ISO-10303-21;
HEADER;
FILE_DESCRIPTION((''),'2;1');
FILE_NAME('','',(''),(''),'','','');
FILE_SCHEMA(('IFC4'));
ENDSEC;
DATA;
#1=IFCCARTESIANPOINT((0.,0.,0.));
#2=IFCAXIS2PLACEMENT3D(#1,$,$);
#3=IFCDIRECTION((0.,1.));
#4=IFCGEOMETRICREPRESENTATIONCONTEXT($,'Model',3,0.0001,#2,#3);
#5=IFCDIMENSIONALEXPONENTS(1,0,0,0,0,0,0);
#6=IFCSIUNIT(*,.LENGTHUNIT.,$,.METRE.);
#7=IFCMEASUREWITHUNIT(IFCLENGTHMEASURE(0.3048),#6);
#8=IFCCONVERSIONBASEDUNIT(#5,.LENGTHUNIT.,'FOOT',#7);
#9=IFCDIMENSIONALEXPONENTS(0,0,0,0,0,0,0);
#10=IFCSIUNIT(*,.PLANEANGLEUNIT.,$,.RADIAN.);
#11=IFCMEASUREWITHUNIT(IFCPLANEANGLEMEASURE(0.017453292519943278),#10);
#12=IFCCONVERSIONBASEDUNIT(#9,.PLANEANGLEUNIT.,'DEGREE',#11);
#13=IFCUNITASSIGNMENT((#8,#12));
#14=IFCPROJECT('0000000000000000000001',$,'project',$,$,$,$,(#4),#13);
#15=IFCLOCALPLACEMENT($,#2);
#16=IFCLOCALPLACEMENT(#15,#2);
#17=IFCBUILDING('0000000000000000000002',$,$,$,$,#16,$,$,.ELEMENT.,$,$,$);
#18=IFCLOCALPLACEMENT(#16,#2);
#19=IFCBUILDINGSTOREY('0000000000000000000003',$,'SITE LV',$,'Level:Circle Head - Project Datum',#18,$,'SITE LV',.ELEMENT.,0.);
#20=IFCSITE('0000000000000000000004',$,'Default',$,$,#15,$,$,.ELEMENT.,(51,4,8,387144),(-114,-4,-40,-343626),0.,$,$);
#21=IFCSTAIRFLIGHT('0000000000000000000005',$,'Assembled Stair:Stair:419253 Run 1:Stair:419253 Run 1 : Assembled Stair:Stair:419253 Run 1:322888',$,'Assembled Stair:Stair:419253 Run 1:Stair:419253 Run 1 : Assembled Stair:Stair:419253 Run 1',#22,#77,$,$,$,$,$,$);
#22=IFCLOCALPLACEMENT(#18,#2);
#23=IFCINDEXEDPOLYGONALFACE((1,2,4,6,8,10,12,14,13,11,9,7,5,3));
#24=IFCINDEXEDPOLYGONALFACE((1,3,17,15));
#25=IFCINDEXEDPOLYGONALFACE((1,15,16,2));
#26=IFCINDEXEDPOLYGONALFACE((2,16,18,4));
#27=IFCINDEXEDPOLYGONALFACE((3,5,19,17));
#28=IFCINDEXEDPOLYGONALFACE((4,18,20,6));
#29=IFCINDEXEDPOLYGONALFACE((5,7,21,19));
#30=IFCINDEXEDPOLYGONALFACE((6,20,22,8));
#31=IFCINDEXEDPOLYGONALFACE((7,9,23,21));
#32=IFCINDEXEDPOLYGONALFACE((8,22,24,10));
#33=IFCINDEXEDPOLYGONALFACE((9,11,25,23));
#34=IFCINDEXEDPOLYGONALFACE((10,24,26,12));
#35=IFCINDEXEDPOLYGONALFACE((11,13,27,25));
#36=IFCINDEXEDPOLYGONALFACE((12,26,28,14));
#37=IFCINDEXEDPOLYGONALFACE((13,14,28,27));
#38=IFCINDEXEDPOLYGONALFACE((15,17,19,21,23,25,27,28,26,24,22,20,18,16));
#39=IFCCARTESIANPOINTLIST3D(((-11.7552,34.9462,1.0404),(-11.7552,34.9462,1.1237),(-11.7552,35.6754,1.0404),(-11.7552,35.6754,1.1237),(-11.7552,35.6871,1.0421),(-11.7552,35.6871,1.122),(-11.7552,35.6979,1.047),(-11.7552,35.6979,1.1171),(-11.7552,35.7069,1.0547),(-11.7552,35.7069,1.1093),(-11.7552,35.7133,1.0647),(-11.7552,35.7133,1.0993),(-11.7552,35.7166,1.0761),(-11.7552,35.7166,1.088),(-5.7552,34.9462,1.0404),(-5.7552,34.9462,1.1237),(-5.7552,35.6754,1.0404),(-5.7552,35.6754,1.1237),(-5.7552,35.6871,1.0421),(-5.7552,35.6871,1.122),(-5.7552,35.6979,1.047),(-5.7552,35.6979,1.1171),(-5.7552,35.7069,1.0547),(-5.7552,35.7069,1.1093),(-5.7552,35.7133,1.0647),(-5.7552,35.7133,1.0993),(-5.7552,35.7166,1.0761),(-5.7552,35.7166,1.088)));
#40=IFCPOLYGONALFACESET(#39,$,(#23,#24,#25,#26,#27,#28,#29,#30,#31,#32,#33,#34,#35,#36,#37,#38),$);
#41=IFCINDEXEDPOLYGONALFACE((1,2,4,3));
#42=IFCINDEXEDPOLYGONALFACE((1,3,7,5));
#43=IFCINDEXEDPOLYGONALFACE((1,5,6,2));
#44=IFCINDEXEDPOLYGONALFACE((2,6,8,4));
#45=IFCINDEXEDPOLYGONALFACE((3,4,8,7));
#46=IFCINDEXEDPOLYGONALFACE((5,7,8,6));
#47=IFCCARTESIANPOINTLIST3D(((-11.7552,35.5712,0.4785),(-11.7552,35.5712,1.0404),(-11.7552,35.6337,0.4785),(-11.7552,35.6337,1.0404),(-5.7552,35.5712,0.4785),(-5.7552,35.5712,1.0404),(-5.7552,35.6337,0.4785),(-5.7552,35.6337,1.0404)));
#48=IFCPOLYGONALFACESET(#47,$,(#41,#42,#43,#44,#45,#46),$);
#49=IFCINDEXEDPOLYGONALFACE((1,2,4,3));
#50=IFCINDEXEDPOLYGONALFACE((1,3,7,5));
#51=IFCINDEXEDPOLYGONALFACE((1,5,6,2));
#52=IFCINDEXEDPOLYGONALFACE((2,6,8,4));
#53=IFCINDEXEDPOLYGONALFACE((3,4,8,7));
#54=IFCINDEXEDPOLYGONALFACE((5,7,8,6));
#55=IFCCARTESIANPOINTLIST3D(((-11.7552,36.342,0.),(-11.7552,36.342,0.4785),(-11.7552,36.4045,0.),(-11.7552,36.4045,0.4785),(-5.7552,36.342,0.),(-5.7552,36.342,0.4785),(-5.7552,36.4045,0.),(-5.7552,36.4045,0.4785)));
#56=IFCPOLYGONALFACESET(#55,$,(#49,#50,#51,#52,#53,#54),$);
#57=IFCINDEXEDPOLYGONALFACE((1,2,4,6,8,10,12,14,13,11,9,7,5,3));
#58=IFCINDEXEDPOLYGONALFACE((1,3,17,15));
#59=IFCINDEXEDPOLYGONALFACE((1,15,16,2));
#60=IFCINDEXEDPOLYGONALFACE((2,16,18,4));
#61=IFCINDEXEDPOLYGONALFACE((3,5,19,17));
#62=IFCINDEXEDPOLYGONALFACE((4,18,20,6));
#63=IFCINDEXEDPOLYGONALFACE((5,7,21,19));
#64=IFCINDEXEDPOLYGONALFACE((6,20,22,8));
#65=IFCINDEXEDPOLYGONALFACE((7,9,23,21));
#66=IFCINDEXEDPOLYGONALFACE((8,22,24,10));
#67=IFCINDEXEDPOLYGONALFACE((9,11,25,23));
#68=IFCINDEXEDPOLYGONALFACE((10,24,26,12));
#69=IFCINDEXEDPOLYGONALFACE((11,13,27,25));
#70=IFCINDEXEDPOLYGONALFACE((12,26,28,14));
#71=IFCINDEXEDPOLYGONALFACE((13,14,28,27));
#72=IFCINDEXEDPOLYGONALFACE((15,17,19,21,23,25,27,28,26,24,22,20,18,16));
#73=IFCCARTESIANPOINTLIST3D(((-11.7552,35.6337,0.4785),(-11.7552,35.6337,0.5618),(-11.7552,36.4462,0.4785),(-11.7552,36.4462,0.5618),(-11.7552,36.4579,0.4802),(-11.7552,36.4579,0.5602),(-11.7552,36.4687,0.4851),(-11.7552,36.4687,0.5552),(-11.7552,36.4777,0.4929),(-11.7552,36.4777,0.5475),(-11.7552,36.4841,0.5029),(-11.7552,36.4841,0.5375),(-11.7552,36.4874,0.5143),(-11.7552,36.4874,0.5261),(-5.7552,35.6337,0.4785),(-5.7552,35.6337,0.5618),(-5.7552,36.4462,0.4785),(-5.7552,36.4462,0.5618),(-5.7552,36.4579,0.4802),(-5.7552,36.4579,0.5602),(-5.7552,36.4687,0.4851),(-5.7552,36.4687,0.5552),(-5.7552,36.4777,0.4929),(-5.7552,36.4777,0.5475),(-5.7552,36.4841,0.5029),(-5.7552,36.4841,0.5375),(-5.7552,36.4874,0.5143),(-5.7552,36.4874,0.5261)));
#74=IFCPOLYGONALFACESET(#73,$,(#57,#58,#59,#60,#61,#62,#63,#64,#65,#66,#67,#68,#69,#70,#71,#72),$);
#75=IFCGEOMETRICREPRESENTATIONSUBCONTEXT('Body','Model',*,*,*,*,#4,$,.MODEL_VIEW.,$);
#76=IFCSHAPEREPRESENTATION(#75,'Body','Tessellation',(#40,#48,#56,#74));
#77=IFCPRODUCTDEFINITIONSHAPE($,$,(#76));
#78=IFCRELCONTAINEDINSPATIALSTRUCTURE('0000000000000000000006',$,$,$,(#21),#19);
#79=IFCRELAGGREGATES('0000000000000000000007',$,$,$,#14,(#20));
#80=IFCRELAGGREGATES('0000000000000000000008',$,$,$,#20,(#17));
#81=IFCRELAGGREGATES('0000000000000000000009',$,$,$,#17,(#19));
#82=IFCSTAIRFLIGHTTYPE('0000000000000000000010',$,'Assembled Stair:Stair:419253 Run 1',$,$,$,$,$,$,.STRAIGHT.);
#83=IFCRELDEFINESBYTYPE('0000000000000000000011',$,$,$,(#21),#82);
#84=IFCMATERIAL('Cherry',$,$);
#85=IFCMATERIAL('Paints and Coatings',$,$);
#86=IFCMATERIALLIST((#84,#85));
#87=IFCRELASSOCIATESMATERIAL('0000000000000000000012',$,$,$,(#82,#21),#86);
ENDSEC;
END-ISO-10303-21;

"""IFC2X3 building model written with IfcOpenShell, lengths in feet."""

from ifc_helpers import new_model, entity, si_unit, converted_unit, direction, frame, frame_2d, origin, place, context, subcontext, project, spatial, polyline, circle_curve, parameter, trimmed, segment, composite_curve, rectangle, outline, extrude, source, transform, mapped, material, material_list, type_object, type_shapes, element, save


model = new_model("IFC2X3")

# Units and contexts
model_context = context("Model", 3, precision=0.0001, world=origin(), true_north=direction((0.0, 1.0)))
body_context = subcontext(model_context, "Body", "Model", "MODEL_VIEW")
ifc_project = project(units=[converted_unit("LENGTHUNIT", "FOOT", entity("IfcLengthMeasure", 0.3048), si_unit("LENGTHUNIT", "METRE"), dimensions=[1, 0, 0, 0, 0, 0, 0]), converted_unit("PLANEANGLEUNIT", "DEGREE", entity("IfcPlaneAngleMeasure", 0.017453292519943278), si_unit("PLANEANGLEUNIT", "RADIAN"), dimensions=[0, 0, 0, 0, 0, 0, 0])], contexts=[model_context])

# Site, building, storey
site_placement = place(None, origin())
site = spatial("IfcSite", under=ifc_project, at=site_placement, Name="Default", CompositionType="ELEMENT", RefLatitude=(51, 4, 8, 387144), RefLongitude=(-114, -4, -40, -343626), RefElevation=0.0)
building_placement = place(site_placement, origin())
building = spatial("IfcBuilding", under=site, at=building_placement, CompositionType="ELEMENT")
storey_placement = place(building_placement, origin())
storey = spatial("IfcBuildingStorey", under=building, at=storey_placement, Name="SITE LV", ObjectType="Level:Circle Head - Project Datum", LongName="SITE LV", CompositionType="ELEMENT", Elevation=0.0)

# Shared definitions
ifc_material_1 = material(Name="Paints and Coatings")

# Stair flight
ifc_material_2 = material(Name="Cherry")
ifc_material_list = material_list([ifc_material_2, ifc_material_1])
stair_flight_type = type_object("IfcStairFlightType", Name="Assembled Stair:Stair:419253 Run 1", PredefinedType="STRAIGHT", material=ifc_material_list)
shared_shape_1 = source(origin(), body_context, "Body", "SweptSolid", [
    extrude(outline(composite_curve([segment(trimmed(circle_curve(frame_2d((-0.3646, 0.0), x_axis=(1.0, 0.0)), 0.0417), [parameter(90.0)], [parameter(270.0)], True, "PARAMETER"), True, "CONTINUOUS"), segment(polyline([(-0.3646, -0.0417), (0.3646, -0.0417)]), True, "CONTINUOUS"), segment(polyline([(0.3646, -0.0417), (0.3646, 0.0417)]), True, "CONTINUOUS"), segment(polyline([(0.3646, 0.0417), (-0.3646, 0.0417)]), True, "CONTINUOUS")], self_intersect=False)), frame((-11.7552, 35.3108, 1.082), z_axis=(1.0, 0.0, 0.0), x_axis=(0.0, -1.0, 0.0)), (0.0, 0.0, 1.0), 6.0),
    extrude(rectangle(XDim=0.0625, YDim=6.0, at=frame_2d((0.0, 0.0), x_axis=(1.0, 0.0))), frame((-8.7552, 35.6024, 0.4785), z_axis=(0.0, 0.0, 1.0), x_axis=(0.0, 1.0, 0.0)), (0.0, 0.0, 1.0), 0.5618),
    extrude(rectangle(XDim=0.0625, YDim=6.0, at=frame_2d((0.0, 0.0), x_axis=(1.0, 0.0))), frame((-8.7552, 36.3733, 0.0), z_axis=(0.0, 0.0, 1.0), x_axis=(0.0, 1.0, 0.0)), (0.0, 0.0, 1.0), 0.4785),
    extrude(outline(composite_curve([segment(trimmed(circle_curve(frame_2d((-0.4062, 0.0), x_axis=(1.0, 0.0)), 0.0417), [parameter(90.0)], [parameter(270.0)], True, "PARAMETER"), True, "CONTINUOUS"), segment(polyline([(-0.4062, -0.0417), (0.4062, -0.0417)]), True, "CONTINUOUS"), segment(polyline([(0.4062, -0.0417), (0.4062, 0.0417)]), True, "CONTINUOUS"), segment(polyline([(0.4062, 0.0417), (-0.4062, 0.0417)]), True, "CONTINUOUS")], self_intersect=False)), frame((-11.7552, 36.0399, 0.5202), z_axis=(1.0, 0.0, 0.0), x_axis=(0.0, -1.0, 0.0)), (0.0, 0.0, 1.0), 6.0),
])
type_shapes(stair_flight_type, [shared_shape_1])
stair_flight_placement = place(storey_placement, origin())
element("IfcStairFlight", 1, at=stair_flight_placement, inside=storey, type_object=stair_flight_type, material=ifc_material_list, Name="Assembled Stair:Stair:419253 Run 1:Stair:419253 Run 1 : Assembled Stair:Stair:419253 Run 1:322888", ObjectType="Assembled Stair:Stair:419253 Run 1:Stair:419253 Run 1 : Assembled Stair:Stair:419253 Run 1", context=body_context, shape_type="MappedRepresentation", body=[
    mapped(shared_shape_1, transform((0.0, 0.0, 0.0), scale=1.0)),
])

save(model, "model.ifc")
